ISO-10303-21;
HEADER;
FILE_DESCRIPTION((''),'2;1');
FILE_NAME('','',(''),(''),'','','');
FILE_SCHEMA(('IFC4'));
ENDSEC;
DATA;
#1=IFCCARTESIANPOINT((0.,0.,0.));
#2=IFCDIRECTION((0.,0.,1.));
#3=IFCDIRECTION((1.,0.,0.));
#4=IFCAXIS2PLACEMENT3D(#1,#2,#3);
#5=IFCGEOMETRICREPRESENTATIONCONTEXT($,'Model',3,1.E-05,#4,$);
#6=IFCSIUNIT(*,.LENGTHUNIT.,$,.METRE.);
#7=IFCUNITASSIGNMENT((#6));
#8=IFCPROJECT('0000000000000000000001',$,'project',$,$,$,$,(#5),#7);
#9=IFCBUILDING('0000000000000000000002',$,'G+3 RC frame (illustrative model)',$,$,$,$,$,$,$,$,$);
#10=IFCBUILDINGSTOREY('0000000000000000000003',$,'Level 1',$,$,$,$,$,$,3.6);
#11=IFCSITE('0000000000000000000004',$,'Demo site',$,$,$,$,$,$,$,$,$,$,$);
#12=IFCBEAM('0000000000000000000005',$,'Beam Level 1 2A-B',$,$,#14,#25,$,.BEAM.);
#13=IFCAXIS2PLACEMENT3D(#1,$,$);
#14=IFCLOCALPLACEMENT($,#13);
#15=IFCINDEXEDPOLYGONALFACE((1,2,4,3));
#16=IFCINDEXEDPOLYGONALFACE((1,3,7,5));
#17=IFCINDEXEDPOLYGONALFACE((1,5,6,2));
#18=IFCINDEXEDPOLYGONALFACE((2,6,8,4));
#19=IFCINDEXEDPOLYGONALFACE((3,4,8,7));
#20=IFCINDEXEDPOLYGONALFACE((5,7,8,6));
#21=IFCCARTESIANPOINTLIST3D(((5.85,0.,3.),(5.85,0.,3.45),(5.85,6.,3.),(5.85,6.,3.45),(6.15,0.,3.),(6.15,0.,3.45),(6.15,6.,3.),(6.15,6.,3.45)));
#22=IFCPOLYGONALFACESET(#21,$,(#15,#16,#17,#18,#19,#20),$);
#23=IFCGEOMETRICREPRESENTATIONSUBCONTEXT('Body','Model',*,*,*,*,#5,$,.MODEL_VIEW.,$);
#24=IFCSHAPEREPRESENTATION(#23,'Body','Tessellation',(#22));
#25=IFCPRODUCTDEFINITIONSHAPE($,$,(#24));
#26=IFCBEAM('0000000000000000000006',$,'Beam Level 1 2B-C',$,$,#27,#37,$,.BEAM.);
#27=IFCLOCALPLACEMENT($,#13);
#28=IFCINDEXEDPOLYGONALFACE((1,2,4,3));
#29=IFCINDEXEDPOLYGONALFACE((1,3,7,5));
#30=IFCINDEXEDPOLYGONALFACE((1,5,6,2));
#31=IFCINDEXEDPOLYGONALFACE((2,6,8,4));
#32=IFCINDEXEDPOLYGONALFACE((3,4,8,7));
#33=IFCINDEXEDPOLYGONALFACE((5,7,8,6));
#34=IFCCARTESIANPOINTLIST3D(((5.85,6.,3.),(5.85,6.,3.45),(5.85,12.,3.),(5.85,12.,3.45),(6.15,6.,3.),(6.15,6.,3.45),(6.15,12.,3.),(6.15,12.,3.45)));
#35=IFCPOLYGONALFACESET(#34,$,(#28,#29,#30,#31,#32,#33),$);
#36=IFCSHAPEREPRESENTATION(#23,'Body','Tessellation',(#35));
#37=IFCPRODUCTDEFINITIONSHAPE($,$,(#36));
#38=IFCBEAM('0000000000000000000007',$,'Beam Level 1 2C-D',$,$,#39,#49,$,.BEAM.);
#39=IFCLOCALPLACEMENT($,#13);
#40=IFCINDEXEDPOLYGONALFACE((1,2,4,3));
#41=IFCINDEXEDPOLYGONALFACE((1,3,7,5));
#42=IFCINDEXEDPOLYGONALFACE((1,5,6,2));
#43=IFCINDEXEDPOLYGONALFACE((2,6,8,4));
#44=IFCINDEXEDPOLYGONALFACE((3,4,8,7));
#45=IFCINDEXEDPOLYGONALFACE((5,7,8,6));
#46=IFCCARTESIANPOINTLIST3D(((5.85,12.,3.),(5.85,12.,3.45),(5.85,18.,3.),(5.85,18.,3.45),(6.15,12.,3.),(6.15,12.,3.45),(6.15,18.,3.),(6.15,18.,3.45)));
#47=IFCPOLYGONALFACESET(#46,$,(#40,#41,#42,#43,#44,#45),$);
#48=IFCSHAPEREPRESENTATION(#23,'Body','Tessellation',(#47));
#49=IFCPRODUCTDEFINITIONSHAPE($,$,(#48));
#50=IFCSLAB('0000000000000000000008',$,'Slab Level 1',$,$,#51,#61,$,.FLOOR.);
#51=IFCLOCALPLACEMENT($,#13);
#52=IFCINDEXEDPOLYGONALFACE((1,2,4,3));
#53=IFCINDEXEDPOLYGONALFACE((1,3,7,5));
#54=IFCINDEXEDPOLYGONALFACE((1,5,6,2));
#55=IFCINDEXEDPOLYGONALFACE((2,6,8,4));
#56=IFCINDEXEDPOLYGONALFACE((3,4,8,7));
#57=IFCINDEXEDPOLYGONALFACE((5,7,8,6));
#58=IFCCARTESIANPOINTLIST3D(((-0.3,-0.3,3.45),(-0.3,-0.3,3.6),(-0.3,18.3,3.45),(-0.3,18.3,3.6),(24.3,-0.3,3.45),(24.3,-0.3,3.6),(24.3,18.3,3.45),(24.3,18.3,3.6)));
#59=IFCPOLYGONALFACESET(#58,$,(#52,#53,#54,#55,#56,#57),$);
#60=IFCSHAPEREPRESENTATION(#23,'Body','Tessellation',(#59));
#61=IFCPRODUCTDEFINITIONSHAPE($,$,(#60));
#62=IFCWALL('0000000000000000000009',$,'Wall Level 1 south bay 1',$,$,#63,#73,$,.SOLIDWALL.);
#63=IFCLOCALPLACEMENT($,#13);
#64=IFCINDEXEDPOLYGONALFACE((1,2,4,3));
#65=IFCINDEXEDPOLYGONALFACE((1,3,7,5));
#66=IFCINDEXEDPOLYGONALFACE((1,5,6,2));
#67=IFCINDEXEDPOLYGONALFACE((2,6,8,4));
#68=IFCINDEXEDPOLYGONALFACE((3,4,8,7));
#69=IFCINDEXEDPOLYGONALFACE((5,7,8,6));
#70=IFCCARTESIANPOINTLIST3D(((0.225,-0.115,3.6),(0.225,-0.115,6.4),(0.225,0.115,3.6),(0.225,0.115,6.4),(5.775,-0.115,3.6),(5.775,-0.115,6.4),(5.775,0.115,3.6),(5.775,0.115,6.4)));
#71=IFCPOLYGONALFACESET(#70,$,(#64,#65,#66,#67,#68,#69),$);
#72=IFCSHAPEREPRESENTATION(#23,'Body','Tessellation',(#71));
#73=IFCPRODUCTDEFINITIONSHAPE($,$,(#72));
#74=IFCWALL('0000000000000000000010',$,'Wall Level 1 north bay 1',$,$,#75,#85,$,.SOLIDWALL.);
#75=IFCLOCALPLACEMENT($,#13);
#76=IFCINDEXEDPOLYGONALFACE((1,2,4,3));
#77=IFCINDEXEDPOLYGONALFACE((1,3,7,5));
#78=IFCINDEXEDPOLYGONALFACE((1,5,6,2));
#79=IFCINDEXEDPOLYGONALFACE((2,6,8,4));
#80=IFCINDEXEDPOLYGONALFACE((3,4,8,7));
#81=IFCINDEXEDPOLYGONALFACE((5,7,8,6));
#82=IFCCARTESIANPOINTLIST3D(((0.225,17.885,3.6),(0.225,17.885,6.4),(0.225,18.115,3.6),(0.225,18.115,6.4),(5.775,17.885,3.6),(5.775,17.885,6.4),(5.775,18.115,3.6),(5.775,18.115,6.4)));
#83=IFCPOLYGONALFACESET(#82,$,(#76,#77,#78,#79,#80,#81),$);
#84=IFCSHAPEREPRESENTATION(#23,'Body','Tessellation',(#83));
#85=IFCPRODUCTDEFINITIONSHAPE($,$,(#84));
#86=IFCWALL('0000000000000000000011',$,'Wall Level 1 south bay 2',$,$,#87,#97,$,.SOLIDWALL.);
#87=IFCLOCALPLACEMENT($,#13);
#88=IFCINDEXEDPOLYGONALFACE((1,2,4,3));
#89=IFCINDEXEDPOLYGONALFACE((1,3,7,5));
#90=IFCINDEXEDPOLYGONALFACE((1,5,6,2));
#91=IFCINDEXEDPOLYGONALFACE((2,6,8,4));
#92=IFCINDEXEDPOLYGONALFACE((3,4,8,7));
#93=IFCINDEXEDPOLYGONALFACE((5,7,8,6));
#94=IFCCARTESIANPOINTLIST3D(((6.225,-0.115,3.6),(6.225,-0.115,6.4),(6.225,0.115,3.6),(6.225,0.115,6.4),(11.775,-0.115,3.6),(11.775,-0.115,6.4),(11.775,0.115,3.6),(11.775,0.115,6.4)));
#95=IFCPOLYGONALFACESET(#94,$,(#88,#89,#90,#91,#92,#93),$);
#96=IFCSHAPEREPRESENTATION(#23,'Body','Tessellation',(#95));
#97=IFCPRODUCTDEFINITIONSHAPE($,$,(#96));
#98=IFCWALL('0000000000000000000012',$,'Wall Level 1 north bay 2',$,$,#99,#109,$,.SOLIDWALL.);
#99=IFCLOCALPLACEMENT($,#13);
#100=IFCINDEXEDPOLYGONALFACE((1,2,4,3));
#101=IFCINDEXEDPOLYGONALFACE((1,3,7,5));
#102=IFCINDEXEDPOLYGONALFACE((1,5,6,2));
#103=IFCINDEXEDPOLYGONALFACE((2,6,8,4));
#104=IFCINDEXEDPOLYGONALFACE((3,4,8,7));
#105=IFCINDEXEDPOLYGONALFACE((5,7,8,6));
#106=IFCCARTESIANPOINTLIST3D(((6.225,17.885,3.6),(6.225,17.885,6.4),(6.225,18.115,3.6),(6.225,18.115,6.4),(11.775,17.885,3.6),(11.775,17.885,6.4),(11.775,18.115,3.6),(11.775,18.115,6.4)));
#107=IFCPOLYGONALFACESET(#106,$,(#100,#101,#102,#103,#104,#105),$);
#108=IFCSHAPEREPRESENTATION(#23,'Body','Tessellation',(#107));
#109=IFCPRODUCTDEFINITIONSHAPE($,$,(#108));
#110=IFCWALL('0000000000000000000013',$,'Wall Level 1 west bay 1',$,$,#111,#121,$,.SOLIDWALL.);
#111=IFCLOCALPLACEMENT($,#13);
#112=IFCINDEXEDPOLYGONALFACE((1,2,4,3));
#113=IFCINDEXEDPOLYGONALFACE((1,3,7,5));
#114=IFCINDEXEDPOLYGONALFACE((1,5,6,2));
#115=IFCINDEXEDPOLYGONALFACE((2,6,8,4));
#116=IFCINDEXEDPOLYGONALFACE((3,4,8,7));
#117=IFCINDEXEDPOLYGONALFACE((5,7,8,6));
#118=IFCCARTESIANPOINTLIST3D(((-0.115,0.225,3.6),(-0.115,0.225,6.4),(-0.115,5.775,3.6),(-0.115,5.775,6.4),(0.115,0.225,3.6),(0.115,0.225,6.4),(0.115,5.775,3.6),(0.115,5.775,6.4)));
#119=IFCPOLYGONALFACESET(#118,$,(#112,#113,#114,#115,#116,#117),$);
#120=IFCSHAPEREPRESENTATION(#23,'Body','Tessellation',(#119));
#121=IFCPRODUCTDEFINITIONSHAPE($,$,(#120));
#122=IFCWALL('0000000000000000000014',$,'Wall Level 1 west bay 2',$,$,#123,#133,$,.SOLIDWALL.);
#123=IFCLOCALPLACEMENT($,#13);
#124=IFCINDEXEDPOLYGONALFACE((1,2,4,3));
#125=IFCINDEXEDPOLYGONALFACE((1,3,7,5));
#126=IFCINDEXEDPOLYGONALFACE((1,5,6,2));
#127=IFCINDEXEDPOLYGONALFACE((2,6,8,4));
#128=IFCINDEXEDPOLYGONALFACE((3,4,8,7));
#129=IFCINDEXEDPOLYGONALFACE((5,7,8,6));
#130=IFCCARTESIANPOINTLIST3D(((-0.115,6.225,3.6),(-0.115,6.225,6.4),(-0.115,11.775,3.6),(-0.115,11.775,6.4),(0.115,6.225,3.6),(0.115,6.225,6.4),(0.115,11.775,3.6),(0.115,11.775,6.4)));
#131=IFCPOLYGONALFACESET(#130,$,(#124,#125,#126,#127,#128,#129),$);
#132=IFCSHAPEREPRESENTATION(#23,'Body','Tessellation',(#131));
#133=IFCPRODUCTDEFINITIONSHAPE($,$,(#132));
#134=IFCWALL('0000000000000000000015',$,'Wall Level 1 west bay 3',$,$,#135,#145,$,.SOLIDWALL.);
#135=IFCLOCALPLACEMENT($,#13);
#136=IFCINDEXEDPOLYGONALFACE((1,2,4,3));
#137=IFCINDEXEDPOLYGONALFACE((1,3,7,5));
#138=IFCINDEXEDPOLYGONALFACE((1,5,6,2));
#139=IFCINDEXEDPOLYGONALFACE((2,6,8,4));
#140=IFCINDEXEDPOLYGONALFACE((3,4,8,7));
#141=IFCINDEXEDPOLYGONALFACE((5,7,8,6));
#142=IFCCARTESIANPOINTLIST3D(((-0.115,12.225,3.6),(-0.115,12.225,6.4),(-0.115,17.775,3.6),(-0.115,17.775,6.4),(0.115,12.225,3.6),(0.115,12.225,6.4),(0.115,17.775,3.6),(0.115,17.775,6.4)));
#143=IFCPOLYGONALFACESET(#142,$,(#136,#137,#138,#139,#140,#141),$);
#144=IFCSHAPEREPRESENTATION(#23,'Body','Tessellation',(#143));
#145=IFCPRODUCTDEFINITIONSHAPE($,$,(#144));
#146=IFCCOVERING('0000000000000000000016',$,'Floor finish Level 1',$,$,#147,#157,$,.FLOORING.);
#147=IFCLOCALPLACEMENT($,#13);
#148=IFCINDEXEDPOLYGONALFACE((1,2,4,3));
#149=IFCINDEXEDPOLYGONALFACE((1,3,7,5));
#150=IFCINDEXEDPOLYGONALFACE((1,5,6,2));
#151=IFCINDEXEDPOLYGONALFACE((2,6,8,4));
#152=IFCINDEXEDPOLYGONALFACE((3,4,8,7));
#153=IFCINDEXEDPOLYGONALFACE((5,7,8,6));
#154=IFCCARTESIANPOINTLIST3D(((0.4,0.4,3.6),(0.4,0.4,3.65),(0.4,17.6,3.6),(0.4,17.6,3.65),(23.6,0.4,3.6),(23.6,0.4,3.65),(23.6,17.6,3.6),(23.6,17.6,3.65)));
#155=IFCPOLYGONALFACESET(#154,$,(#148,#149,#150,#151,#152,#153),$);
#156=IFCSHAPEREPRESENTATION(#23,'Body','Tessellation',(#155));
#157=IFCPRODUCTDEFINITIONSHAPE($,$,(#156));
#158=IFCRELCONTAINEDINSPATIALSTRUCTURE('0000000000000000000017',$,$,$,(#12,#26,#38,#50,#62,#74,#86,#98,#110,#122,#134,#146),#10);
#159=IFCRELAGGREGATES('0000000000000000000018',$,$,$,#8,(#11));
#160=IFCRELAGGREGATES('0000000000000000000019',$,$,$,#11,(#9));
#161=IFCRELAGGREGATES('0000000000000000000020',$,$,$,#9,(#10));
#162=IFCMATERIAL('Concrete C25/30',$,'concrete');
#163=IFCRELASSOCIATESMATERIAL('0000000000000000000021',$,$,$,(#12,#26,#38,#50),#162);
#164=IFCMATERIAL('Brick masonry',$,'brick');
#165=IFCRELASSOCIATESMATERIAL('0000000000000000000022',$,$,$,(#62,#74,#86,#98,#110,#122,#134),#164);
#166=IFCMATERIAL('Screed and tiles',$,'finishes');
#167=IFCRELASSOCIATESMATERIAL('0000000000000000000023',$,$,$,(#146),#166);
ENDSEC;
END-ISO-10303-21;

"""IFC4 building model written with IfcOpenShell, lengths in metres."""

from ifc_helpers import new_model, si_unit, frame, frame_2d, origin, origin_with_axes, place, context, subcontext, project, spatial, rectangle, extrude, material, element, save


model = new_model("IFC4")

# Units and contexts
model_context = context("Model", 3, precision=1e-05, world=origin_with_axes())
body_context = subcontext(model_context, "Body", "Model", "MODEL_VIEW")
ifc_project = project(units=[si_unit("LENGTHUNIT", "METRE")], contexts=[model_context])

# Site, building, storey
site = spatial("IfcSite", under=ifc_project, Name="Demo site")
building = spatial("IfcBuilding", under=site, Name="G+3 RC frame (illustrative model)")
storey = spatial("IfcBuildingStorey", under=building, Name="Level 1", Elevation=3.6)

# Shared definitions
ifc_material_1 = material(Name="Concrete C25/30", Category="concrete")

# Beams
for number, where, z_axis, x_axis, name in (
    (1, (5.85, 0.0, 3.0), (0.0, 0.0, 1.0), (1.0, 0.0, 0.0), "Beam Level 1 2A-B"),
    (2, (5.85, 6.0, 3.0), (0.0, 0.0, 1.0), (1.0, 0.0, 0.0), "Beam Level 1 2B-C"),
    (3, (5.85, 12.0, 3.0), (0.0, 0.0, 1.0), (1.0, 0.0, 0.0), "Beam Level 1 2C-D"),
):
    element("IfcBeam", number, at=place(None, frame(where, z_axis=z_axis, x_axis=x_axis)), inside=storey, material=ifc_material_1, Name=name, PredefinedType="BEAM", context=body_context, shape_type="SweptSolid", body=[
        extrude(rectangle(XDim=0.3, YDim=6.0, at=frame_2d((0.15, 3.0))), origin(), (0.0, 0.0, 1.0), 0.45),
    ])

# Slab
slab_placement = place(None, frame((-0.3, -0.3, 3.45), z_axis=(0.0, 0.0, 1.0), x_axis=(1.0, 0.0, 0.0)))
element("IfcSlab", 4, at=slab_placement, inside=storey, material=ifc_material_1, Name="Slab Level 1", PredefinedType="FLOOR", context=body_context, shape_type="SweptSolid", body=[
    extrude(rectangle(XDim=24.6, YDim=18.6, at=frame_2d((12.3, 9.3))), origin(), (0.0, 0.0, 1.0), 0.15),
])

# Walls
ifc_material_2 = material(Name="Brick masonry", Category="brick")
for number, where, z_axis, x_axis, name in (
    (5, (0.225, -0.115, 3.6), (0.0, 0.0, 1.0), (1.0, 0.0, 0.0), "Wall Level 1 south bay 1"),
    (6, (0.225, 17.885, 3.6), (0.0, 0.0, 1.0), (1.0, 0.0, 0.0), "Wall Level 1 north bay 1"),
    (7, (6.225, -0.115, 3.6), (0.0, 0.0, 1.0), (1.0, 0.0, 0.0), "Wall Level 1 south bay 2"),
    (8, (6.225, 17.885, 3.6), (0.0, 0.0, 1.0), (1.0, 0.0, 0.0), "Wall Level 1 north bay 2"),
):
    element("IfcWall", number, at=place(None, frame(where, z_axis=z_axis, x_axis=x_axis)), inside=storey, material=ifc_material_2, Name=name, PredefinedType="SOLIDWALL", context=body_context, shape_type="SweptSolid", body=[
        extrude(rectangle(XDim=5.55, YDim=0.23, at=frame_2d((2.775, 0.115))), origin(), (0.0, 0.0, 1.0), 2.8),
    ])
for number, where, z_axis, x_axis, name in (
    (9, (-0.115, 0.225, 3.6), (0.0, 0.0, 1.0), (1.0, 0.0, 0.0), "Wall Level 1 west bay 1"),
    (10, (-0.115, 6.225, 3.6), (0.0, 0.0, 1.0), (1.0, 0.0, 0.0), "Wall Level 1 west bay 2"),
    (11, (-0.115, 12.225, 3.6), (0.0, 0.0, 1.0), (1.0, 0.0, 0.0), "Wall Level 1 west bay 3"),
):
    element("IfcWall", number, at=place(None, frame(where, z_axis=z_axis, x_axis=x_axis)), inside=storey, material=ifc_material_2, Name=name, PredefinedType="SOLIDWALL", context=body_context, shape_type="SweptSolid", body=[
        extrude(rectangle(XDim=0.23, YDim=5.55, at=frame_2d((0.115, 2.775))), origin(), (0.0, 0.0, 1.0), 2.8),
    ])

# Covering
ifc_material_3 = material(Name="Screed and tiles", Category="finishes")
covering_placement = place(None, frame((0.4, 0.4, 3.6), z_axis=(0.0, 0.0, 1.0), x_axis=(1.0, 0.0, 0.0)))
element("IfcCovering", 12, at=covering_placement, inside=storey, material=ifc_material_3, Name="Floor finish Level 1", PredefinedType="FLOORING", context=body_context, shape_type="SweptSolid", body=[
    extrude(rectangle(XDim=23.2, YDim=17.2, at=frame_2d((11.6, 8.6))), origin(), (0.0, 0.0, 1.0), 0.05),
])

save(model, "model.ifc")
